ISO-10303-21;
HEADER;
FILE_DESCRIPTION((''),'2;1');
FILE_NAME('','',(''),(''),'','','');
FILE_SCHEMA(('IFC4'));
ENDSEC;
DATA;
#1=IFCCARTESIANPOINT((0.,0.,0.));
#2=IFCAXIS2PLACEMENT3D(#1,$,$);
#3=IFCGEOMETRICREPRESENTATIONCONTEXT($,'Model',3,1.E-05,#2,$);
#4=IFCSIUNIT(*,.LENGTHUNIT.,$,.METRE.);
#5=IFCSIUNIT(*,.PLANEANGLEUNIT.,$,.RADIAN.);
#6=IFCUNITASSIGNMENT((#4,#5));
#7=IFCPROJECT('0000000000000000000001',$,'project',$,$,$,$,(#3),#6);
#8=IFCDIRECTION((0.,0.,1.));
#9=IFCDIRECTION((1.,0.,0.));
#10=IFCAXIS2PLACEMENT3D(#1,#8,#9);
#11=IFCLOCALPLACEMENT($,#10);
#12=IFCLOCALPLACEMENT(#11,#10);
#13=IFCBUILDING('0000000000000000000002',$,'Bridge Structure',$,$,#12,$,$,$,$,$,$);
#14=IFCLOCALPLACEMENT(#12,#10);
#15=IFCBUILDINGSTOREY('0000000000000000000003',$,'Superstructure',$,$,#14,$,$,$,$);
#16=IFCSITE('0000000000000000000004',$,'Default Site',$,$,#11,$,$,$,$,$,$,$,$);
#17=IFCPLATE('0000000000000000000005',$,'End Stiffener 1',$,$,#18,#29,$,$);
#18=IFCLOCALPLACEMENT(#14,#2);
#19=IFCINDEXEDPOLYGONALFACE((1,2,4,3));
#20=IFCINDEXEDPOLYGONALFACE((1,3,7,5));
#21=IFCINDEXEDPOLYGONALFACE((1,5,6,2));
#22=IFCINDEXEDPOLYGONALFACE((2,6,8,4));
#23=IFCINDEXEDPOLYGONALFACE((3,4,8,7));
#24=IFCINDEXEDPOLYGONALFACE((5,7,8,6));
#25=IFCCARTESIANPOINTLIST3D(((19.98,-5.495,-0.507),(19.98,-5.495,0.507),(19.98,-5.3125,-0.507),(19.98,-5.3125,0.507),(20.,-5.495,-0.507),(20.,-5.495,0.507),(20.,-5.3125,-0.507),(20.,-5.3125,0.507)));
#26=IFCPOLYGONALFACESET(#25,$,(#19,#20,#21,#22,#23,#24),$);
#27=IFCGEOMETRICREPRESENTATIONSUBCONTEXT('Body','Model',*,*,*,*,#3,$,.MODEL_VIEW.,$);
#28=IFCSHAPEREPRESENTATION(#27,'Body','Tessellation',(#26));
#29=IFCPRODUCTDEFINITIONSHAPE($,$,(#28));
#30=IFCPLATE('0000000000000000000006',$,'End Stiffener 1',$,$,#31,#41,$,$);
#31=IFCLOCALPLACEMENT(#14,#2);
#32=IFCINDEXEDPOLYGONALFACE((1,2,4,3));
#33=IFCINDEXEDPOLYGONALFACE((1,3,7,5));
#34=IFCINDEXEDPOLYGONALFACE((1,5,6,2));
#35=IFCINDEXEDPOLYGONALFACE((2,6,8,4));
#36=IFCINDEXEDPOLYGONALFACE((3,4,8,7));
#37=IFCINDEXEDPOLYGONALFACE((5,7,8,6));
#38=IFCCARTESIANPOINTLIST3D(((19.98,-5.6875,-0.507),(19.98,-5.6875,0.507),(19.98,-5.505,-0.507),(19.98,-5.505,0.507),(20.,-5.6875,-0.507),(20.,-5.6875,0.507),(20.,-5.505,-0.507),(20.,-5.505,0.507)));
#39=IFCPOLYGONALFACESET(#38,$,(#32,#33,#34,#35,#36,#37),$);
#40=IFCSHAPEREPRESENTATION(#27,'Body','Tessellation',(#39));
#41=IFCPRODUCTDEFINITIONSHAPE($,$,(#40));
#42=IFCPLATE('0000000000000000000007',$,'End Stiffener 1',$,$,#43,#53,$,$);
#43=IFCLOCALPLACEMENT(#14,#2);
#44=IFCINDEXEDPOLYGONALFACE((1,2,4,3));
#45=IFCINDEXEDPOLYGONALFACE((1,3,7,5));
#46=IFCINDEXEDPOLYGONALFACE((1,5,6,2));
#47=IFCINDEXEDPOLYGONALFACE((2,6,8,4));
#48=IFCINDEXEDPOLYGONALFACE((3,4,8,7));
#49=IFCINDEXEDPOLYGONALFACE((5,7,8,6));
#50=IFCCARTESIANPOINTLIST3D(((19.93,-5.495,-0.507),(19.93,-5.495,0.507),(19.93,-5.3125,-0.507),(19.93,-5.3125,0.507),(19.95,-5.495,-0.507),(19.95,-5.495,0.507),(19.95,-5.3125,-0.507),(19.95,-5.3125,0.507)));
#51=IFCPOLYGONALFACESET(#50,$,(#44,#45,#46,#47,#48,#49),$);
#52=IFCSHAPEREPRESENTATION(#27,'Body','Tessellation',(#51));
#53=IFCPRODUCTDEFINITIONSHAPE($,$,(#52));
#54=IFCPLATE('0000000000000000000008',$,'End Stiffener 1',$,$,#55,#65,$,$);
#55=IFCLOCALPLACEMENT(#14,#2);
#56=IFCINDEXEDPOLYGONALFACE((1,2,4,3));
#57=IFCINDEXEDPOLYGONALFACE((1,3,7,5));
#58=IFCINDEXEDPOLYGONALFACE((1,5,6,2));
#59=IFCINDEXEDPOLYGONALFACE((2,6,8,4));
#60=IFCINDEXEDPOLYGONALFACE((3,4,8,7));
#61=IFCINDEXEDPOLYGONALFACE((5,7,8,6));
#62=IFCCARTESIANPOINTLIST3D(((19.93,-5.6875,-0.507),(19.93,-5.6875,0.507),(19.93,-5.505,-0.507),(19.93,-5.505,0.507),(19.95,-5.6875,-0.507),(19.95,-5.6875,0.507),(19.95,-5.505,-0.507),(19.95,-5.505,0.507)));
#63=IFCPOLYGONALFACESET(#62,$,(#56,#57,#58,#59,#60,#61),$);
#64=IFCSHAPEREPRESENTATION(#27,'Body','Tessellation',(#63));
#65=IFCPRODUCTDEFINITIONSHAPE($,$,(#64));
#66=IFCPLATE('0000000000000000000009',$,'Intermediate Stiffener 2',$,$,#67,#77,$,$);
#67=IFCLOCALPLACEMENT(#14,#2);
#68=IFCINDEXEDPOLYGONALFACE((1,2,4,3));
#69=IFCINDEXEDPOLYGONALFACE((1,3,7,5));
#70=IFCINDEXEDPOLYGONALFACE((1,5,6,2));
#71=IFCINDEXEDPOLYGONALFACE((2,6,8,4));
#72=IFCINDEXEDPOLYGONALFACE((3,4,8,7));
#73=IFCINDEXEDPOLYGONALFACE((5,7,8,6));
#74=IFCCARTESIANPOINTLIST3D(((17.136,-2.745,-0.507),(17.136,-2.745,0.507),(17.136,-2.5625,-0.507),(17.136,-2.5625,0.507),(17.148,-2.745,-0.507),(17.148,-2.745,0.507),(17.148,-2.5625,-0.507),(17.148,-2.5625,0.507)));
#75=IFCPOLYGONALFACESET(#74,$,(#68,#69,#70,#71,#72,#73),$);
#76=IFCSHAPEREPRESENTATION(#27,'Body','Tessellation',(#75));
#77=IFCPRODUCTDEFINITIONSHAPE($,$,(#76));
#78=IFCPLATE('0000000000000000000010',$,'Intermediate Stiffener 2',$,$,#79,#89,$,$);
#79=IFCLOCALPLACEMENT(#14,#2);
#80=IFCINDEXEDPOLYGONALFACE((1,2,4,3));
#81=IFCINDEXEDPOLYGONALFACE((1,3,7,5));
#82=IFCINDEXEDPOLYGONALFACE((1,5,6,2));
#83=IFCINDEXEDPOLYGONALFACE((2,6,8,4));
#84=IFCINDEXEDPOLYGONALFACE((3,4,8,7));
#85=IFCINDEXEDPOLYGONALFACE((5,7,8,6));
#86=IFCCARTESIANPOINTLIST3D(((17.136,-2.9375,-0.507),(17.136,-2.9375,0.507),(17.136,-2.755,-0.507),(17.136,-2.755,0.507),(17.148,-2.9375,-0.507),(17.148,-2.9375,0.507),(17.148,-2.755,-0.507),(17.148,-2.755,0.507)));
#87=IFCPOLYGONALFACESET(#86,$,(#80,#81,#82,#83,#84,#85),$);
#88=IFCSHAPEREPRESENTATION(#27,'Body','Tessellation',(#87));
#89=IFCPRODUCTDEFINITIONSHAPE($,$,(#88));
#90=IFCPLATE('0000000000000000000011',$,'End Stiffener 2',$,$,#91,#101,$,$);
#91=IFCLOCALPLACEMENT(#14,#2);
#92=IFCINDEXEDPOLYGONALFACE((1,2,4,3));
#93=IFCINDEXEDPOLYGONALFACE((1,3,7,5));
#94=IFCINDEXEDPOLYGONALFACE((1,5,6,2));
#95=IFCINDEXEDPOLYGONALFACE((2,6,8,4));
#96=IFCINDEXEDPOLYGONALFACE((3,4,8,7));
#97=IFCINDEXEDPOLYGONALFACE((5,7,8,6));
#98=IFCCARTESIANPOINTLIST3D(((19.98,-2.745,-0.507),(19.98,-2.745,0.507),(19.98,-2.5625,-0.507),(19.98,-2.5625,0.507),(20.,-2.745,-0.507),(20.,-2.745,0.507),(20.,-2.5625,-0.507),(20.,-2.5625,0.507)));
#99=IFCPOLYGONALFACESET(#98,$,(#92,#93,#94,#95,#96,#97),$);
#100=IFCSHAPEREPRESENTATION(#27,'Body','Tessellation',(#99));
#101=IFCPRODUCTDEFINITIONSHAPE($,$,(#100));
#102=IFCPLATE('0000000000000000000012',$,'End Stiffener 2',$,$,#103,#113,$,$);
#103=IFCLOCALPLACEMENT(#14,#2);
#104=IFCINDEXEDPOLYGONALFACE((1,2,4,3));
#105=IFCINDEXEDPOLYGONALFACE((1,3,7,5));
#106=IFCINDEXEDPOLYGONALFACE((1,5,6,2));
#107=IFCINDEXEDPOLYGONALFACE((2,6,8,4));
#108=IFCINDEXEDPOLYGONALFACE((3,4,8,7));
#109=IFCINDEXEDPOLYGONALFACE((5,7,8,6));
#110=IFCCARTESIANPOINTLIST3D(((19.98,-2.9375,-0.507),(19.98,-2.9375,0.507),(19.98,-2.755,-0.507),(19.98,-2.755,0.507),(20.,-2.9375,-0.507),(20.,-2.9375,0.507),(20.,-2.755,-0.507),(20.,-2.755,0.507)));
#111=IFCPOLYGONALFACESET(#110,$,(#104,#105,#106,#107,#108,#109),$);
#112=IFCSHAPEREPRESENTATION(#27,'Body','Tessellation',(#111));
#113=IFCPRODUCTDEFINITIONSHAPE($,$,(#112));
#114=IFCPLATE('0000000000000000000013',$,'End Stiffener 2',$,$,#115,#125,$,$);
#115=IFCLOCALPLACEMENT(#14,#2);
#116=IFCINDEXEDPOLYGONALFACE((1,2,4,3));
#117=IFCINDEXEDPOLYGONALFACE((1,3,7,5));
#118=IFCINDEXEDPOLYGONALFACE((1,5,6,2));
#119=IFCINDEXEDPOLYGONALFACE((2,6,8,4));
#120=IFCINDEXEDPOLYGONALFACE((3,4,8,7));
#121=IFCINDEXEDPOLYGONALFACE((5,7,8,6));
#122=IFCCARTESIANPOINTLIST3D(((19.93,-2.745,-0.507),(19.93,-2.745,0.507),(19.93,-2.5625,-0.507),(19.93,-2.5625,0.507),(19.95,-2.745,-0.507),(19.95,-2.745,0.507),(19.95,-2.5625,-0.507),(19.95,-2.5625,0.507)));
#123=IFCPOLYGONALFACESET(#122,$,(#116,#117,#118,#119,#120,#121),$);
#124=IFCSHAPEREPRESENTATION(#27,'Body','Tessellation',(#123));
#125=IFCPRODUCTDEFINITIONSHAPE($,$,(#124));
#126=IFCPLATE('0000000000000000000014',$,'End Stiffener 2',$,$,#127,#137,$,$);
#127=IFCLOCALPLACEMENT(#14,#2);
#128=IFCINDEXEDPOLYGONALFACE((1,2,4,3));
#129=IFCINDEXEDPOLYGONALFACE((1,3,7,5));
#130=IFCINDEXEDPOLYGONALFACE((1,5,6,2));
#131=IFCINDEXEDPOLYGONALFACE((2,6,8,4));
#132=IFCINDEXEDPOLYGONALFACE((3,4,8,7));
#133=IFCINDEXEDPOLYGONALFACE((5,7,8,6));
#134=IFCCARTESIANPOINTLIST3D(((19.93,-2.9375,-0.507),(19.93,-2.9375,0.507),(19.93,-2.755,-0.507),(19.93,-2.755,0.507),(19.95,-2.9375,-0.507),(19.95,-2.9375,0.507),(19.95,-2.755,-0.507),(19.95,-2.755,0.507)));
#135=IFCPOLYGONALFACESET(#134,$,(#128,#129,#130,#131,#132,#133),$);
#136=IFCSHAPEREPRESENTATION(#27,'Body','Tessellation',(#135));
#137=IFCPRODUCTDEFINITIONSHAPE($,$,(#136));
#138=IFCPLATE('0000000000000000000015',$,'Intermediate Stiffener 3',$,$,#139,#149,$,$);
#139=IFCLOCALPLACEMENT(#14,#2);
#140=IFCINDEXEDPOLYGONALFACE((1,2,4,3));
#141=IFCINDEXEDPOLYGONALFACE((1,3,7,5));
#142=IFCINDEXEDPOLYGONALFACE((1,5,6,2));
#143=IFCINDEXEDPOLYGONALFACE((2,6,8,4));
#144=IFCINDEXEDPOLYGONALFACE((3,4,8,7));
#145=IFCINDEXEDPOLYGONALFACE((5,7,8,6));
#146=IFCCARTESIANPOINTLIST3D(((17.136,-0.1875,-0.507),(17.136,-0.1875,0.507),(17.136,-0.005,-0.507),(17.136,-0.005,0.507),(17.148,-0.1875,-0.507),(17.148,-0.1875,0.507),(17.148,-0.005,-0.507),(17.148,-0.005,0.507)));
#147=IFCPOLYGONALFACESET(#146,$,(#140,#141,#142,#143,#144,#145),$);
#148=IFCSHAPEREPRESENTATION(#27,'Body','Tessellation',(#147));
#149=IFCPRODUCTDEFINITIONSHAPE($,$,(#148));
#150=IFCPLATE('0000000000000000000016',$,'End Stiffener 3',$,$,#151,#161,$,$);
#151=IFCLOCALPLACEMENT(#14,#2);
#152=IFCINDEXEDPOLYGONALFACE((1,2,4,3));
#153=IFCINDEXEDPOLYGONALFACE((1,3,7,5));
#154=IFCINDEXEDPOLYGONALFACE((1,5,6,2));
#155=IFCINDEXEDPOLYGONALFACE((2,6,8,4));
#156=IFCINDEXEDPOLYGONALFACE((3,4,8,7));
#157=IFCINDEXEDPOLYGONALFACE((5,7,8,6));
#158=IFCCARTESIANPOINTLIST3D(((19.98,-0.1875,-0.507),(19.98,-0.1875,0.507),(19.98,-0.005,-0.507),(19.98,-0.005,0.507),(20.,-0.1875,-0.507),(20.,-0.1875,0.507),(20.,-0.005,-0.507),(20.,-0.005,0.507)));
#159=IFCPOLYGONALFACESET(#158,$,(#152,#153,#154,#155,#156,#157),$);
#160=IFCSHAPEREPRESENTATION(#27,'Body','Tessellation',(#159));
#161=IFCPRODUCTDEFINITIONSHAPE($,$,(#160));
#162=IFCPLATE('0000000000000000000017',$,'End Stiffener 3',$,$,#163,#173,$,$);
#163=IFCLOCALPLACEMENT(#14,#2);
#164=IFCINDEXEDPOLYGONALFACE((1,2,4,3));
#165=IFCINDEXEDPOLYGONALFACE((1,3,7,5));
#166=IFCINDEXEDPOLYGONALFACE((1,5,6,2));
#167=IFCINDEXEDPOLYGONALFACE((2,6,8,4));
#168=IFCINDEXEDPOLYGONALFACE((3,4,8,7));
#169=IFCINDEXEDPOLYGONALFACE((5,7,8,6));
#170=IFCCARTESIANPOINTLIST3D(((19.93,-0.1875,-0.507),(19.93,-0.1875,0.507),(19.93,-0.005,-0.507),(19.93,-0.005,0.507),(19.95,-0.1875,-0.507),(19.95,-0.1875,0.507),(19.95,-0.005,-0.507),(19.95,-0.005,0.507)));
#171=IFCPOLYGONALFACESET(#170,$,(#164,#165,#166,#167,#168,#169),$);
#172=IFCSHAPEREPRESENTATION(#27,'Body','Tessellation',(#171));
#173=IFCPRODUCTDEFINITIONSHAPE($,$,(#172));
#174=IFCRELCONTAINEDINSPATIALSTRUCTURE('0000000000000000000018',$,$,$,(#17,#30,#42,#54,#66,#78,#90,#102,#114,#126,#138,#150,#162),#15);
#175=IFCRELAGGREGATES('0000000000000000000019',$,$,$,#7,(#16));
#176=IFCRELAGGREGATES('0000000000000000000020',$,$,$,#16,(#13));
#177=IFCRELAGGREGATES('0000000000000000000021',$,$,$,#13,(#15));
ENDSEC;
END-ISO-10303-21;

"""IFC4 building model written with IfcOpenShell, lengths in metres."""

from ifc_helpers import new_model, si_unit, frame, origin, origin_with_axes, origin_2d_with_axis, place, context, subcontext, project, spatial, rectangle, extrude, element, save


model = new_model("IFC4")

# Units and contexts
model_context = context("Model", 3, precision=1e-05, world=origin())
body_context = subcontext(model_context, "Body", "Model", "MODEL_VIEW")
ifc_project = project(units=[si_unit("LENGTHUNIT", "METRE"), si_unit("PLANEANGLEUNIT", "RADIAN")], contexts=[model_context])

# Site, building, storey
site_placement = place(None, origin_with_axes())
site = spatial("IfcSite", under=ifc_project, at=site_placement, Name="Default Site")
building_placement = place(site_placement, origin_with_axes())
building = spatial("IfcBuilding", under=site, at=building_placement, Name="Bridge Structure")
storey_placement = place(building_placement, origin_with_axes())
storey = spatial("IfcBuildingStorey", under=building, at=storey_placement, Name="Superstructure")

# Plates
for number, where, z_axis, x_axis, name in (
    (1, (19.99, -5.4038, -0.507), (0.0, 0.0, 1.0), (1.0, 0.0, 0.0), "End Stiffener 1"),
    (2, (19.99, -5.5963, -0.507), (0.0, 0.0, 1.0), (1.0, 0.0, 0.0), "End Stiffener 1"),
    (3, (19.94, -5.4038, -0.507), (0.0, 0.0, 1.0), (1.0, 0.0, 0.0), "End Stiffener 1"),
    (4, (19.94, -5.5963, -0.507), (0.0, 0.0, 1.0), (1.0, 0.0, 0.0), "End Stiffener 1"),
):
    element("IfcPlate", number, at=place(storey_placement, frame(where, z_axis=z_axis, x_axis=x_axis)), inside=storey, Name=name, context=body_context, shape_type="SweptSolid", body=[
        extrude(rectangle(XDim=0.02, YDim=0.1825, at=origin_2d_with_axis()), origin_with_axes(), (0.0, 0.0, 1.0), 1.014),
    ])
for number, where, z_axis, x_axis, name in (
    (5, (17.142, -2.6538, -0.507), (0.0, 0.0, 1.0), (1.0, 0.0, 0.0), "Intermediate Stiffener 2"),
    (6, (17.142, -2.8462, -0.507), (0.0, 0.0, 1.0), (1.0, 0.0, 0.0), "Intermediate Stiffener 2"),
):
    element("IfcPlate", number, at=place(storey_placement, frame(where, z_axis=z_axis, x_axis=x_axis)), inside=storey, Name=name, context=body_context, shape_type="SweptSolid", body=[
        extrude(rectangle(XDim=0.012, YDim=0.1825, at=origin_2d_with_axis()), origin_with_axes(), (0.0, 0.0, 1.0), 1.014),
    ])
for number, where, z_axis, x_axis, name in (
    (7, (19.99, -2.6538, -0.507), (0.0, 0.0, 1.0), (1.0, 0.0, 0.0), "End Stiffener 2"),
    (8, (19.99, -2.8462, -0.507), (0.0, 0.0, 1.0), (1.0, 0.0, 0.0), "End Stiffener 2"),
    (9, (19.94, -2.6538, -0.507), (0.0, 0.0, 1.0), (1.0, 0.0, 0.0), "End Stiffener 2"),
    (10, (19.94, -2.8462, -0.507), (0.0, 0.0, 1.0), (1.0, 0.0, 0.0), "End Stiffener 2"),
):
    element("IfcPlate", number, at=place(storey_placement, frame(where, z_axis=z_axis, x_axis=x_axis)), inside=storey, Name=name, context=body_context, shape_type="SweptSolid", body=[
        extrude(rectangle(XDim=0.02, YDim=0.1825, at=origin_2d_with_axis()), origin_with_axes(), (0.0, 0.0, 1.0), 1.014),
    ])
plate_placement = place(storey_placement, frame((17.142, -0.0963, -0.507), z_axis=(0.0, 0.0, 1.0), x_axis=(1.0, 0.0, 0.0)))
element("IfcPlate", 11, at=plate_placement, inside=storey, Name="Intermediate Stiffener 3", context=body_context, shape_type="SweptSolid", body=[
    extrude(rectangle(XDim=0.012, YDim=0.1825, at=origin_2d_with_axis()), origin_with_axes(), (0.0, 0.0, 1.0), 1.014),
])
for number, where, z_axis, x_axis, name in (
    (12, (19.99, -0.0963, -0.507), (0.0, 0.0, 1.0), (1.0, 0.0, 0.0), "End Stiffener 3"),
    (13, (19.94, -0.0963, -0.507), (0.0, 0.0, 1.0), (1.0, 0.0, 0.0), "End Stiffener 3"),
):
    element("IfcPlate", number, at=place(storey_placement, frame(where, z_axis=z_axis, x_axis=x_axis)), inside=storey, Name=name, context=body_context, shape_type="SweptSolid", body=[
        extrude(rectangle(XDim=0.02, YDim=0.1825, at=origin_2d_with_axis()), origin_with_axes(), (0.0, 0.0, 1.0), 1.014),
    ])

save(model, "model.ifc")
